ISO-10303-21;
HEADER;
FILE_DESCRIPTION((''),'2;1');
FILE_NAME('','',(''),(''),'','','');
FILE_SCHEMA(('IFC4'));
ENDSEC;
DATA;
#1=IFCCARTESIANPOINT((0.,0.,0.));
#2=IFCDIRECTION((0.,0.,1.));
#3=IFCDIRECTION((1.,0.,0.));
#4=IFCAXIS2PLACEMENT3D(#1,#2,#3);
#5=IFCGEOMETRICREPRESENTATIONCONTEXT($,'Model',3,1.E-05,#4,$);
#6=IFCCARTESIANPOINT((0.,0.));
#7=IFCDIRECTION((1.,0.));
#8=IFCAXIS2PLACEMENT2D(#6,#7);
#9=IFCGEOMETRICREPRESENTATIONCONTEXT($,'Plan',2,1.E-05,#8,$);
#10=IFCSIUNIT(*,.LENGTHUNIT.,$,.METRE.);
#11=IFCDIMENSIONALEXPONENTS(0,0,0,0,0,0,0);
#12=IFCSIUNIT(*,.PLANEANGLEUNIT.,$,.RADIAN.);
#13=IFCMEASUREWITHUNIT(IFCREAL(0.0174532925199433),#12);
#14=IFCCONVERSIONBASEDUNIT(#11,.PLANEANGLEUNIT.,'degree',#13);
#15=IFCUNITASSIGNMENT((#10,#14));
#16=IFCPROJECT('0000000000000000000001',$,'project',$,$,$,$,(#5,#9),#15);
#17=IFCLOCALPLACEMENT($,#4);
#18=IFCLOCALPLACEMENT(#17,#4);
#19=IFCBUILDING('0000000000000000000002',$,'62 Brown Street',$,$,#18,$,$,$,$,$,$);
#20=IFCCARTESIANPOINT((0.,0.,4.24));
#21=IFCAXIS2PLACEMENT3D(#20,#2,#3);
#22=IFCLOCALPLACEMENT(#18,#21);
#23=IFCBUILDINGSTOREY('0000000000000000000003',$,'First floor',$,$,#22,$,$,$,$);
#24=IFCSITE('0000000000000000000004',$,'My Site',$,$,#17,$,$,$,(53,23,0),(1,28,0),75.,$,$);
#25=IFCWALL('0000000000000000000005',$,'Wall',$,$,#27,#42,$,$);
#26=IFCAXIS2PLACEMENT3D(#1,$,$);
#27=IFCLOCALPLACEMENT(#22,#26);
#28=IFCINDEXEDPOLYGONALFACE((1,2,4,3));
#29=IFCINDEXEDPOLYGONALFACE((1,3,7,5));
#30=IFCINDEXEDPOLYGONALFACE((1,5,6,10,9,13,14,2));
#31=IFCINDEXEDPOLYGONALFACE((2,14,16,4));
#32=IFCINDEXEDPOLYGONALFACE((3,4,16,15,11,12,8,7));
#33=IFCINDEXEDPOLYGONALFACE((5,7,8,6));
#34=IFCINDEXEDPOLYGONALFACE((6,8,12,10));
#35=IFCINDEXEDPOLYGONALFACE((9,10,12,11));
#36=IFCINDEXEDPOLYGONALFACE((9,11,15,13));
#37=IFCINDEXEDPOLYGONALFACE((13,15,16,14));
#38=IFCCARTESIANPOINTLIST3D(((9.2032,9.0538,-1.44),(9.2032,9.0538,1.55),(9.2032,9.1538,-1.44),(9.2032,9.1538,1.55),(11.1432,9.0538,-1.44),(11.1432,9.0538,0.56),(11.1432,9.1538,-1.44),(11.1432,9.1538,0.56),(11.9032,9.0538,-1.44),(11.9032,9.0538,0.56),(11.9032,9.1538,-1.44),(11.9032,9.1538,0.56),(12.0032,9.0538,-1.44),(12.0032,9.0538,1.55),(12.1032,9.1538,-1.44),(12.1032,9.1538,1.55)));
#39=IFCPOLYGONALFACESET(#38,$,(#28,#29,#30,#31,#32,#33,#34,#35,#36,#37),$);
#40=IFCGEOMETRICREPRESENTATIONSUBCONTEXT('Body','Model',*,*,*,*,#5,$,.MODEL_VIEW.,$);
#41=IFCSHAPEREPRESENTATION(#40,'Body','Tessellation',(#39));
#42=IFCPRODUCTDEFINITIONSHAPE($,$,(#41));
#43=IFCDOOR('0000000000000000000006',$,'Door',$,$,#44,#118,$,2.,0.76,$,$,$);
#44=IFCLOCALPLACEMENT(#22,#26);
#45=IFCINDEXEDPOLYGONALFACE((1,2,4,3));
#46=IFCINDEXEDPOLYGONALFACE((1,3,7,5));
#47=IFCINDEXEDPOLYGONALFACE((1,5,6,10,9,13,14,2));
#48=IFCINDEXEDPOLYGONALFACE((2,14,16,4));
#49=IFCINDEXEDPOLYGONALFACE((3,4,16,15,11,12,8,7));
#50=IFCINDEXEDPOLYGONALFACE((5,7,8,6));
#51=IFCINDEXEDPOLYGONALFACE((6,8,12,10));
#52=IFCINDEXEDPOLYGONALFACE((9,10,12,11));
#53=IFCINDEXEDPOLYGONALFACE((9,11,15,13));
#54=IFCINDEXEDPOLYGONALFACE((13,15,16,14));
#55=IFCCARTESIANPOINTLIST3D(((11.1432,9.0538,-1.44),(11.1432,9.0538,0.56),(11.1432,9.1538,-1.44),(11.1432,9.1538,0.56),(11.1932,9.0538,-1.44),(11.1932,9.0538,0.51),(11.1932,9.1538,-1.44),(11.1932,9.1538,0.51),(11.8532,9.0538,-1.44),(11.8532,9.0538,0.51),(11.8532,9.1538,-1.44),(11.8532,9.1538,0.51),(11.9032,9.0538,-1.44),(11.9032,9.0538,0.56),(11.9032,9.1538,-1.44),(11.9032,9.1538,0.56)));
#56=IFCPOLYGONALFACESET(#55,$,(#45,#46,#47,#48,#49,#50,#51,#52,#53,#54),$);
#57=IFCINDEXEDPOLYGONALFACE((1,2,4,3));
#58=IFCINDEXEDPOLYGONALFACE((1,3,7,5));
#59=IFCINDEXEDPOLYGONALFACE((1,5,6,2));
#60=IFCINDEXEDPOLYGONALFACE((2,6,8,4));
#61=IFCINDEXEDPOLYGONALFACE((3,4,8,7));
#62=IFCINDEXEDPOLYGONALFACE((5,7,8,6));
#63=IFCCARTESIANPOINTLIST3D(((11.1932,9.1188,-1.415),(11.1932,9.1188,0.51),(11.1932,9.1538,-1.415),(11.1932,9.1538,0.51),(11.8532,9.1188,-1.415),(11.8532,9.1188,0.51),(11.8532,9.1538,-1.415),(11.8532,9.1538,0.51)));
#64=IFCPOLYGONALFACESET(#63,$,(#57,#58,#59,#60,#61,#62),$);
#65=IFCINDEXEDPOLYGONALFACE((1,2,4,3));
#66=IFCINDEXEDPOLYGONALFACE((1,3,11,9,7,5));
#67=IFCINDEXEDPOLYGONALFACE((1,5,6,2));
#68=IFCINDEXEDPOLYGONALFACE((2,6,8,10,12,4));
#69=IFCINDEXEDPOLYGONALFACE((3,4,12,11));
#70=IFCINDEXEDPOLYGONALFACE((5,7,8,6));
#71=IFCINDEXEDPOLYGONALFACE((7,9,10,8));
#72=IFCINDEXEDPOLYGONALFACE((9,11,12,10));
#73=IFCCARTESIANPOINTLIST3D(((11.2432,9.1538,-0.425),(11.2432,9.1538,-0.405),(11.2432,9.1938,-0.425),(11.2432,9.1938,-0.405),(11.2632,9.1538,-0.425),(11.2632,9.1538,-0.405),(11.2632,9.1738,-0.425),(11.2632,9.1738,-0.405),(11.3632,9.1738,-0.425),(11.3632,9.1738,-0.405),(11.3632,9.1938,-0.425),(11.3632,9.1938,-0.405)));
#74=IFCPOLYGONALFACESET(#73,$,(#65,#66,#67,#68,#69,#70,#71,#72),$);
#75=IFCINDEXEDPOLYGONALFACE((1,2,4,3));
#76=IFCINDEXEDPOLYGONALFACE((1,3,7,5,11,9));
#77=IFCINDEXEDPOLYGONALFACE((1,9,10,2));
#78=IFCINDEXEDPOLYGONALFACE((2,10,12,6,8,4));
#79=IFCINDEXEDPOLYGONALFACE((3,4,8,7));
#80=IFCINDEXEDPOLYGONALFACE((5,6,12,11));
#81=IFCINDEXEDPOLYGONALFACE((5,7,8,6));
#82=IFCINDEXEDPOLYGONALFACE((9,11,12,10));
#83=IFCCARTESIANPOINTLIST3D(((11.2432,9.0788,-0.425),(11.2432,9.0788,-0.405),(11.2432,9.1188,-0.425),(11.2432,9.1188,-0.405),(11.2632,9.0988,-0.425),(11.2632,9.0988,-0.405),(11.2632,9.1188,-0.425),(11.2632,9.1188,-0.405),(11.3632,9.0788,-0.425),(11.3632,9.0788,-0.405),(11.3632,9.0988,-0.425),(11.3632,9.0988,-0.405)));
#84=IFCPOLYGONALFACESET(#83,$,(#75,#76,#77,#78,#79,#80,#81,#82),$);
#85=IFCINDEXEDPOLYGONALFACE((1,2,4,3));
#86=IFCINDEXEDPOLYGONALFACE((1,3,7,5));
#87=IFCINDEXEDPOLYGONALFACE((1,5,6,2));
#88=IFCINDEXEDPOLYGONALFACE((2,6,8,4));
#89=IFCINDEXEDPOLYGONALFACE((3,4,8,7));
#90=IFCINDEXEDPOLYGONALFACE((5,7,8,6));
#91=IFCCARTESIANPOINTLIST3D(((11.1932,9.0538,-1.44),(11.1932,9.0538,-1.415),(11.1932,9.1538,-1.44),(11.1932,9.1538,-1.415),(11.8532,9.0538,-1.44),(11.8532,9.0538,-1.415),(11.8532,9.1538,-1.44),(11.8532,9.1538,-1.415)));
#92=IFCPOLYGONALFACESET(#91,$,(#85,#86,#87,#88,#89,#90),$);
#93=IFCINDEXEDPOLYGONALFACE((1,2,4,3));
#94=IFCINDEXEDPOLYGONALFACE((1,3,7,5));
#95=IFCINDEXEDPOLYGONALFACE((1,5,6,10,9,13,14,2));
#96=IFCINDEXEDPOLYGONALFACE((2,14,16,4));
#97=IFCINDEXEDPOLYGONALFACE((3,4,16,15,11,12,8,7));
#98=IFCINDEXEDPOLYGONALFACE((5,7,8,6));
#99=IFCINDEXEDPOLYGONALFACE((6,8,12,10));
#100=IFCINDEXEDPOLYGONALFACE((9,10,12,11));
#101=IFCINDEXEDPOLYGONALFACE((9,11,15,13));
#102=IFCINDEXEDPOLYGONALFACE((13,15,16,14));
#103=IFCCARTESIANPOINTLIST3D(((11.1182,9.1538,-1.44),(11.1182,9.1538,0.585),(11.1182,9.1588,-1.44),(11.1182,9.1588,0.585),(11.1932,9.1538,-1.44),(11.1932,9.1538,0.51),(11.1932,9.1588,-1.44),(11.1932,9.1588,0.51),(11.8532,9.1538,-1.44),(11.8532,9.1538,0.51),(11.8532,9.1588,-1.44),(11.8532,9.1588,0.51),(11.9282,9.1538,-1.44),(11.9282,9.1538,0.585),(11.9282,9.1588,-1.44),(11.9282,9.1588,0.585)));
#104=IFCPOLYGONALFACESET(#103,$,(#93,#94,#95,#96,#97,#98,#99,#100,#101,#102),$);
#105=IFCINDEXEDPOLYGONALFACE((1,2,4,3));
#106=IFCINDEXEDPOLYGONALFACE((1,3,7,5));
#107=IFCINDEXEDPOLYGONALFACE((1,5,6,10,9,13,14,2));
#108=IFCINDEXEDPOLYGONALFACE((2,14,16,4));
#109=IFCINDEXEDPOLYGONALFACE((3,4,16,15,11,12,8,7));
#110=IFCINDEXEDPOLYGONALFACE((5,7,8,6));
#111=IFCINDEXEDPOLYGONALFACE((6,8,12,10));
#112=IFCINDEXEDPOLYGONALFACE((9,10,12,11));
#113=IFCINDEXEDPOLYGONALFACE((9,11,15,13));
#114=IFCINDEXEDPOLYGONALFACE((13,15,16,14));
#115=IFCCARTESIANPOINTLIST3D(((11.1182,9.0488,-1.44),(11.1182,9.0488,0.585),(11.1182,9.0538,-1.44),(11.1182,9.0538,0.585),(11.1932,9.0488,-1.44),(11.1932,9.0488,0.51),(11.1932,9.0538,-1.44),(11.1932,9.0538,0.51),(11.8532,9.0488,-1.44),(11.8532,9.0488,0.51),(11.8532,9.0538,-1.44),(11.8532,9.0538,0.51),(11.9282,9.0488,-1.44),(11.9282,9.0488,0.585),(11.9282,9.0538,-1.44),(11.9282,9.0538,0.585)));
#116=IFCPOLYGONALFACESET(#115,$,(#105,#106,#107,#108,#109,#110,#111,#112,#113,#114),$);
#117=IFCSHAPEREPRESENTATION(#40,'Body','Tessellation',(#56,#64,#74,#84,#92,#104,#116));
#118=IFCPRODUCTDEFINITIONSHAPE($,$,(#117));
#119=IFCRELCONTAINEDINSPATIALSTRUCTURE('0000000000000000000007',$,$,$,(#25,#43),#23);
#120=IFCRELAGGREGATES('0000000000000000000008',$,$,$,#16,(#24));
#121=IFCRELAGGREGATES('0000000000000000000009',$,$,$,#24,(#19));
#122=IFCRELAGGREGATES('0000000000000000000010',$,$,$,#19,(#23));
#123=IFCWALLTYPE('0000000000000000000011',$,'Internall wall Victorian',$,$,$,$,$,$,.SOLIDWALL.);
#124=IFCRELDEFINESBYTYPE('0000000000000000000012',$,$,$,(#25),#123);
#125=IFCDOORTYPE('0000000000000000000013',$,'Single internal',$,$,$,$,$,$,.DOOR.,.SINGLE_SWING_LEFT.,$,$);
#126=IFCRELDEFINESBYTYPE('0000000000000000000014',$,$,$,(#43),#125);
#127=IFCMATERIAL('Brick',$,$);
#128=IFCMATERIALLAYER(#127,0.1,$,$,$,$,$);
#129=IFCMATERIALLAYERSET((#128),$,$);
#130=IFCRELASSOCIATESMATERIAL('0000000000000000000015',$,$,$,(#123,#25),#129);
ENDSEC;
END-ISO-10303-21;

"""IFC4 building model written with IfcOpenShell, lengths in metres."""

from ifc_helpers import new_model, entity, si_unit, converted_unit, frame, origin_with_axes, origin_2d_with_axis, place, context, subcontext, project, spatial, line, indexed_curve, outline, extrude, clip, halfspace, shape, source, transform, mapped, material, layer, layer_set, layer_usage, type_object, type_shapes, element, fill, save


model = new_model("IFC4")

# Units and contexts
model_context = context("Model", 3, precision=1e-05, world=origin_with_axes())
plan_context = context("Plan", 2, precision=1e-05, world=origin_2d_with_axis())
body_context_1 = subcontext(model_context, "Body", "Model", "MODEL_VIEW")
body_context_2 = subcontext(plan_context, "Body", "Plan", "PLAN_VIEW")
ifc_project = project(units=[si_unit("LENGTHUNIT", "METRE"), converted_unit("PLANEANGLEUNIT", "degree", entity("IfcReal", 0.0174532925199433), si_unit("PLANEANGLEUNIT", "RADIAN"), dimensions=[0, 0, 0, 0, 0, 0, 0])], contexts=[model_context, plan_context])

# Site, building, storey
site_placement = place(None, origin_with_axes())
site = spatial("IfcSite", under=ifc_project, at=site_placement, Name="My Site", RefLatitude=(53, 23, 0), RefLongitude=(1, 28, 0), RefElevation=75.0)
building_placement = place(site_placement, origin_with_axes())
building = spatial("IfcBuilding", under=site, at=building_placement, Name="62 Brown Street")
storey_placement = place(building_placement, frame((0.0, 0.0, 4.24), z_axis=(0.0, 0.0, 1.0), x_axis=(1.0, 0.0, 0.0)))
storey = spatial("IfcBuildingStorey", under=building, at=storey_placement, Name="First floor")

# Shared definitions
ifc_material_1 = material(Name="Brick")

# Shared definitions
ifc_layer_1 = layer(ifc_material_1, 0.1)
ifc_layer_set_1 = layer_set([ifc_layer_1])
wall_type_1 = type_object("IfcWallType", Name="Internall wall Victorian", PredefinedType="SOLIDWALL", material=ifc_layer_set_1)

# Wall, opening, door
ifc_layer_usage_1 = layer_usage(ifc_layer_set_1, "AXIS2", "POSITIVE", 0.0)
wall_1_placement = place(storey_placement, frame((12.1032, 9.1538, -1.44), z_axis=(0.0, 0.0, 1.0), x_axis=(-1.0, 0.0, 0.0)))
wall_1 = element("IfcWall", 1, at=wall_1_placement, inside=storey, type_object=wall_type_1, material=ifc_layer_usage_1, Name="Wall", context=body_context_1, shape_type="Clipping", body=[
    clip(extrude(outline(indexed_curve([(0.0, 0.0), (0.0, 0.1), (2.9, 0.1), (2.9, 0.0), (0.0, 0.0)], self_intersect=False)), origin_with_axes(), (0.0, 0.0, 1.0), 2.99), halfspace(frame((0.0, 0.0, -2.8), z_axis=(-0.299001, 0.299001, 0.0), x_axis=(0.1, 0.1, 0.0)), False)),
])
shared_shape_1 = source(origin_with_axes(), body_context_1, "Body", "SweptSolid", [
    extrude(outline(indexed_curve([(0.0, 0.0), (0.76, 0.0), (0.76, 2.0), (0.0, 2.0)], segments=[line(1, 2, 3, 4, 1)])), frame((0.0, -0.6, 0.0), z_axis=(0.0, -1.0, 0.0), x_axis=(1.0, 0.0, 0.0)), (0.0, 0.0, -1.0), 1.2),
])
opening_1_placement = place(wall_1_placement, frame((0.2, 0.0, 0.0), z_axis=(0.0, 0.0, 1.0), x_axis=(1.0, 0.0, 0.0)))
opening_1 = element("IfcOpeningElement", 2, at=opening_1_placement, cuts=wall_1, PredefinedType="OPENING", context=body_context_1, shape_type="MappedRepresentation", body=[
    mapped(shared_shape_1, transform((0.0, 0.0, 0.0), x_axis=(1.0, 0.0, 0.0), y_axis=(0.0, 1.0, 0.0), z_axis=(0.0, 0.0, 1.0), scale=1.0)),
])
door_type = type_object("IfcDoorType", Name="Single internal", OperationType="SINGLE_SWING_LEFT", PredefinedType="DOOR")
shared_shape_2 = source(origin_with_axes(), body_context_1, "Body", "SweptSolid", [
    extrude(outline(indexed_curve([(0.0, 0.0), (0.0, 2.0), (0.76, 2.0), (0.76, 0.0), (0.71, 0.0), (0.71, 1.95), (0.05, 1.95), (0.05, 0.0)], segments=[line(1, 2, 3, 4, 5, 6, 7, 8, 1)])), frame((0.0, 0.0, 0.0), z_axis=(0.0, -1.0, 0.0), x_axis=(1.0, 0.0, 0.0)), (0.0, 0.0, -1.0), 0.1),
    extrude(outline(indexed_curve([(0.0, 0.0), (0.66, 0.0), (0.66, 0.035), (0.0, 0.035)], segments=[line(1, 2, 3, 4, 1)])), frame((0.05, 0.0, 0.025), z_axis=(0.0, 0.0, 1.0), x_axis=(1.0, 0.0, 0.0)), (0.0, 0.0, 1.0), 1.925),
    extrude(outline(indexed_curve([(0.0, 0.0), (0.0, -0.04), (-0.12, -0.04), (-0.12, -0.02), (-0.02, -0.02), (-0.02, 0.0)], segments=[line(1, 2, 3, 4, 5, 6, 1)])), frame((0.66, 0.0, 1.015), z_axis=(0.0, 0.0, 1.0), x_axis=(1.0, 0.0, 0.0)), (0.0, 0.0, 1.0), 0.02),
    extrude(outline(indexed_curve([(0.0, 0.0), (0.0, 0.04), (-0.12, 0.04), (-0.12, 0.02), (-0.02, 0.02), (-0.02, 0.0)], segments=[line(1, 2, 3, 4, 5, 6, 1)])), frame((0.66, 0.035, 1.015), z_axis=(0.0, 0.0, 1.0), x_axis=(1.0, 0.0, 0.0)), (0.0, 0.0, 1.0), 0.02),
    extrude(outline(indexed_curve([(0.0, 0.0), (0.66, 0.0), (0.66, 0.1), (0.0, 0.1)], segments=[line(1, 2, 3, 4, 1)])), frame((0.05, 0.0, 0.0), z_axis=(0.0, 0.0, 1.0), x_axis=(1.0, 0.0, 0.0)), (0.0, 0.0, 1.0), 0.025),
    extrude(outline(indexed_curve([(0.0, 0.0), (0.0, 2.025), (0.81, 2.025), (0.81, 0.0), (0.735, 0.0), (0.735, 1.95), (0.075, 1.95), (0.075, 0.0)], segments=[line(1, 2, 3, 4, 5, 6, 7, 8, 1)])), frame((-0.025, -0.005, 0.0), z_axis=(0.0, -1.0, 0.0), x_axis=(1.0, 0.0, 0.0)), (0.0, 0.0, -1.0), 0.005),
    extrude(outline(indexed_curve([(0.0, 0.0), (0.0, 2.025), (0.81, 2.025), (0.81, 0.0), (0.735, 0.0), (0.735, 1.95), (0.075, 1.95), (0.075, 0.0)], segments=[line(1, 2, 3, 4, 5, 6, 7, 8, 1)])), frame((-0.025, 0.1, 0.0), z_axis=(0.0, -1.0, 0.0), x_axis=(1.0, 0.0, 0.0)), (0.0, 0.0, -1.0), 0.005),
])
shared_shape_3 = source(origin_with_axes(), body_context_2, "Body", "Curve2D", [
    entity("IfcIndexedPolyCurve", entity("IfcCartesianPointList2D", [[0.0, 0.0], [0.05, 0.0], [0.05, 0.1], [0.0, 0.1]]), [entity("IfcLineIndex", [1, 2, 3, 4, 1])]),
    entity("IfcIndexedPolyCurve", entity("IfcCartesianPointList2D", [[0.76, 0.0], [0.71, 0.0], [0.71, 0.1], [0.76, 0.1]]), [entity("IfcLineIndex", [1, 2, 3, 4, 1])]),
    entity("IfcTrimmedCurve", entity("IfcEllipse", entity("IfcAxis2Placement2D", entity("IfcCartesianPoint", [0.085, 0.1]), entity("IfcDirection", [1.0, 0.0])), 0.625, 0.66), [entity("IfcCartesianPoint", [0.71, 0.1])], [entity("IfcCartesianPoint", [0.085, 0.76])], True, "CARTESIAN"),
    entity("IfcIndexedPolyCurve", entity("IfcCartesianPointList2D", [[0.05, 0.1], [0.085, 0.1], [0.085, 0.76], [0.05, 0.76]]), [entity("IfcLineIndex", [1, 2, 3, 4, 1])]),
])
type_shapes(door_type, [shared_shape_2, shared_shape_3])
door_placement = place(opening_1_placement, frame((0.0, 0.0, 0.0), z_axis=(0.0, 0.0, 1.0), x_axis=(1.0, 0.0, 0.0)))
door = element("IfcDoor", 3, at=door_placement, inside=storey, type_object=door_type, Name="Door", OverallHeight=2.0, OverallWidth=0.76, shapes=[
    shape(body_context_1, "Body", "MappedRepresentation", [mapped(shared_shape_2, transform((0.0, 0.0, 0.0), x_axis=(1.0, 0.0, 0.0), y_axis=(0.0, 1.0, 0.0), z_axis=(0.0, 0.0, 1.0), scale=1.0))]),
    shape(body_context_2, "Body", "MappedRepresentation", [mapped(shared_shape_3, transform((0.0, 0.0, 0.0), x_axis=(1.0, 0.0, 0.0), y_axis=(0.0, 1.0, 0.0), z_axis=(0.0, 0.0, 1.0), scale=1.0))]),
])
fill(opening_1, door)

save(model, "model.ifc")
